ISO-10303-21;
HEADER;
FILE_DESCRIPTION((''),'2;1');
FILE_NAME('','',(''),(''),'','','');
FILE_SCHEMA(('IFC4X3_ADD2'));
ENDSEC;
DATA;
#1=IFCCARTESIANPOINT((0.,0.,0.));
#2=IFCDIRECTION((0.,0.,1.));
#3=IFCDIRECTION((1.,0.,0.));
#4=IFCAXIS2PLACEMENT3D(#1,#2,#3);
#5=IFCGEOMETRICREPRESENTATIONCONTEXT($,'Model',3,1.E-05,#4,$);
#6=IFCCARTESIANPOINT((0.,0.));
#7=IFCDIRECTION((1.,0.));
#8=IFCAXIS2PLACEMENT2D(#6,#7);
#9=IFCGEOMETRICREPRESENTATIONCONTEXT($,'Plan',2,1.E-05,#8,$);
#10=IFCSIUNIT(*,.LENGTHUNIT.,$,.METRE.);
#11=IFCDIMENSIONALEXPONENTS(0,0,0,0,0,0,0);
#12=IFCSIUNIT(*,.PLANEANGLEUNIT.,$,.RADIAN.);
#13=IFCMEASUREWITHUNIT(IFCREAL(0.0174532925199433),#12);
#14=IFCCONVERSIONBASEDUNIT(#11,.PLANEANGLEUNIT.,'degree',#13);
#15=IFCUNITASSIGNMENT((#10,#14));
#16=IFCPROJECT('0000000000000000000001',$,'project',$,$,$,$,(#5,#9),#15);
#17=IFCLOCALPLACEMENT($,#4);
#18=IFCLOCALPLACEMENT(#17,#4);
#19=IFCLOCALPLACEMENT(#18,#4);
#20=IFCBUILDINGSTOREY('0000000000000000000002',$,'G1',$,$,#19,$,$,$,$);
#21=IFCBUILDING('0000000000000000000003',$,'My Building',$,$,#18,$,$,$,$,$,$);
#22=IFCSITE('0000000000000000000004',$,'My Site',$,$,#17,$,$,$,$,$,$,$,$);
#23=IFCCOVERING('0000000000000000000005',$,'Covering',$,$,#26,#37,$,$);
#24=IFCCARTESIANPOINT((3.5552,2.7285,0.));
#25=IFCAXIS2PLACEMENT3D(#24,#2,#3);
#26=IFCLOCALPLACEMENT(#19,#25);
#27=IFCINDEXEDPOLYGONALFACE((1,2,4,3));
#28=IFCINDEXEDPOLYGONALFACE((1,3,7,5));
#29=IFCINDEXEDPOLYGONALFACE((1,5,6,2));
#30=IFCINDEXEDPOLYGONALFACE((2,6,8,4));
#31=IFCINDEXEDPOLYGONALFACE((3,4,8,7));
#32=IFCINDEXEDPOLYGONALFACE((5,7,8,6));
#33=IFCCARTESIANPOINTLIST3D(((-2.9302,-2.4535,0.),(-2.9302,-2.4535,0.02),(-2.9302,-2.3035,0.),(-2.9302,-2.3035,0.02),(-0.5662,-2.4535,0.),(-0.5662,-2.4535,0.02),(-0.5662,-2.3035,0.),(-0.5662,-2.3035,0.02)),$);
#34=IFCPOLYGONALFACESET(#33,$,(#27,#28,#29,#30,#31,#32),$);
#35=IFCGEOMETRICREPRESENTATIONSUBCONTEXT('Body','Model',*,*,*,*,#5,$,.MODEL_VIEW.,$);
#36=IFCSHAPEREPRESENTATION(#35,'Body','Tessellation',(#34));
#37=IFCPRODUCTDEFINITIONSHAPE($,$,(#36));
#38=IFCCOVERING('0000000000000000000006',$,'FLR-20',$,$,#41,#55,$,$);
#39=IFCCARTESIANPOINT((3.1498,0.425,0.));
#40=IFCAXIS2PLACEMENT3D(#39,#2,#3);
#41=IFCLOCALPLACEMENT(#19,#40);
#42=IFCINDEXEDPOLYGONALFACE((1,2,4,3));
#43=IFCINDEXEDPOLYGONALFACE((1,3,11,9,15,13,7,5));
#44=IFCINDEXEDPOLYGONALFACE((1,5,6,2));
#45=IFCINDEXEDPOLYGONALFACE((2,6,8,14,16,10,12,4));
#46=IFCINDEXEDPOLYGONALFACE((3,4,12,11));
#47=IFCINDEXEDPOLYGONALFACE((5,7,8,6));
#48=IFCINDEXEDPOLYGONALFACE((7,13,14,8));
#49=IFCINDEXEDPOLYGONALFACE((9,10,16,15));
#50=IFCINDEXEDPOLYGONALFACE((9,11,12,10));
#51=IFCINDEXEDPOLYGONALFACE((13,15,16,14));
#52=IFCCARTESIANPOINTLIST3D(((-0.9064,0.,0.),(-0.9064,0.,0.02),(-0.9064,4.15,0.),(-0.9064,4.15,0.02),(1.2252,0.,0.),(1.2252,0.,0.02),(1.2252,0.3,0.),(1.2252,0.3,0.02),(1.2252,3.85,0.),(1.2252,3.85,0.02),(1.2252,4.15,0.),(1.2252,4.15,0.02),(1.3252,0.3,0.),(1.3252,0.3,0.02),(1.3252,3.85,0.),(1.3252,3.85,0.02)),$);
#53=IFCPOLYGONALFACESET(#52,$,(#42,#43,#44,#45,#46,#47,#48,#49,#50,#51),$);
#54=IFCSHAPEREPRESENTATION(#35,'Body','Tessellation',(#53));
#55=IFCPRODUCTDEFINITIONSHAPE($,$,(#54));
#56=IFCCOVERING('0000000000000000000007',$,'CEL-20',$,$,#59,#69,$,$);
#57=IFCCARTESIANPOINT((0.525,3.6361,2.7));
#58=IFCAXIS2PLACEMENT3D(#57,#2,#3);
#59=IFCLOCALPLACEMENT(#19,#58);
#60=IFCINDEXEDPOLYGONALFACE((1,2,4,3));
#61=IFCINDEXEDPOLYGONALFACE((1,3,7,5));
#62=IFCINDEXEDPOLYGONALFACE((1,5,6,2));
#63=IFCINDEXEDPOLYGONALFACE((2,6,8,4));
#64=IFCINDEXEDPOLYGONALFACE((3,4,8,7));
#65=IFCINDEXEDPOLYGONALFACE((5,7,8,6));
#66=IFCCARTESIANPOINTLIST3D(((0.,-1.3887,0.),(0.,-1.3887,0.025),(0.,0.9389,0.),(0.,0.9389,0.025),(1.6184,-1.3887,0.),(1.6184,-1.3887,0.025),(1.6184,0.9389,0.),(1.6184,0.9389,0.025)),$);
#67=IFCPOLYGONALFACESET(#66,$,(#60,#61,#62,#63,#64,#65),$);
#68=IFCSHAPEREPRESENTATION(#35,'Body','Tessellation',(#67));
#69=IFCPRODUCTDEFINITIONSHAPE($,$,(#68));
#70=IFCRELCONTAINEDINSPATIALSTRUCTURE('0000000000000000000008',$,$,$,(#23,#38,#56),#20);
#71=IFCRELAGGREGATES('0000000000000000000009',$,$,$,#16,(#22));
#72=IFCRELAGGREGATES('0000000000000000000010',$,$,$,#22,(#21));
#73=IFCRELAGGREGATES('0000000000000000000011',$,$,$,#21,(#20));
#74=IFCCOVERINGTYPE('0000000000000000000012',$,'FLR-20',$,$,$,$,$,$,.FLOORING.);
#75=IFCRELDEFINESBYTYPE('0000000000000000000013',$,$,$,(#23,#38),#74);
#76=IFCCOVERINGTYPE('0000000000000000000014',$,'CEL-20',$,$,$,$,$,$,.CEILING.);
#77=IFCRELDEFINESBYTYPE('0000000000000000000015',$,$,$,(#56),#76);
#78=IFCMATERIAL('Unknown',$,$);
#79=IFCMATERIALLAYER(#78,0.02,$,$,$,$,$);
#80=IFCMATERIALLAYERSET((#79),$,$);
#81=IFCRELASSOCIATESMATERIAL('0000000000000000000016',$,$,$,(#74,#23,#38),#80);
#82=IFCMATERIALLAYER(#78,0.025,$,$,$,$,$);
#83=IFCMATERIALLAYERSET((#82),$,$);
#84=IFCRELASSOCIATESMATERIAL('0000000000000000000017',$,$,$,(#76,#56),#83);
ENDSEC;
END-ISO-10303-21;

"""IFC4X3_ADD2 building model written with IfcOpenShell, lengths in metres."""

from ifc_helpers import new_model, entity, si_unit, converted_unit, frame, origin_with_axes, origin_2d_with_axis, place, context, subcontext, project, spatial, line, indexed_curve, outline, extrude, material, layer, layer_set, layer_usage, type_object, element, save


model = new_model("IFC4X3_ADD2")

# Units and contexts
model_context = context("Model", 3, precision=1e-05, world=origin_with_axes())
plan_context = context("Plan", 2, precision=1e-05, world=origin_2d_with_axis())
body_context = subcontext(model_context, "Body", "Model", "MODEL_VIEW")
ifc_project = project(units=[si_unit("LENGTHUNIT", "METRE"), converted_unit("PLANEANGLEUNIT", "degree", entity("IfcReal", 0.0174532925199433), si_unit("PLANEANGLEUNIT", "RADIAN"), dimensions=[0, 0, 0, 0, 0, 0, 0])], contexts=[model_context, plan_context])

# Site, building, storey
site_placement = place(None, origin_with_axes())
site = spatial("IfcSite", under=ifc_project, at=site_placement, Name="My Site")
building_placement = place(site_placement, origin_with_axes())
building = spatial("IfcBuilding", under=site, at=building_placement, Name="My Building")
storey_placement = place(building_placement, origin_with_axes())
storey = spatial("IfcBuildingStorey", under=building, at=storey_placement, Name="G1")

# Coverings
ifc_material_1 = material(Name="Unknown")
ifc_layer_1 = layer(ifc_material_1, 0.02)
ifc_layer_set_1 = layer_set([ifc_layer_1])
ifc_layer_usage_1 = layer_usage(ifc_layer_set_1, "AXIS3", "POSITIVE", 0.0)
covering_type_1 = type_object("IfcCoveringType", Name="FLR-20", PredefinedType="FLOORING", material=ifc_layer_set_1)
covering_1_placement = place(storey_placement, frame((3.5552, 2.7285, 0.0), z_axis=(0.0, 0.0, 1.0), x_axis=(1.0, 0.0, 0.0)))
element("IfcCovering", 1, at=covering_1_placement, inside=storey, type_object=covering_type_1, material=ifc_layer_usage_1, Name="Covering", context=body_context, shape_type="SweptSolid", body=[
    extrude(outline(indexed_curve([(-2.9302, -2.4535), (-2.9302, -2.3035), (-0.5662, -2.3035), (-0.5662, -2.4535), (-2.9302, -2.4535)], segments=[line(1, 2, 3, 4, 5, 1)])), None, (0.0, 0.0, 1.0), 0.02),
])
ifc_layer_usage_2 = layer_usage(ifc_layer_set_1, "AXIS3", "POSITIVE", 0.0)
covering_2_placement = place(storey_placement, frame((3.1498, 0.425, 0.0), z_axis=(0.0, 0.0, 1.0), x_axis=(1.0, 0.0, 0.0)))
element("IfcCovering", 2, at=covering_2_placement, inside=storey, type_object=covering_type_1, material=ifc_layer_usage_2, Name="FLR-20", context=body_context, shape_type="SweptSolid", body=[
    extrude(outline(indexed_curve([(1.2252, 0.0), (1.2252, 0.3), (1.3252, 0.3), (1.3252, 3.85), (1.2252, 3.85), (1.2252, 4.15), (-0.9064, 4.15), (-0.9064, 0.0), (1.2252, 0.0)])), None, (0.0, 0.0, 1.0), 0.02),
])
ifc_layer_2 = layer(ifc_material_1, 0.025)
ifc_layer_set_2 = layer_set([ifc_layer_2])
ifc_layer_usage_3 = layer_usage(ifc_layer_set_2, "AXIS3", "POSITIVE", 0.0)
covering_type_2 = type_object("IfcCoveringType", Name="CEL-20", PredefinedType="CEILING", material=ifc_layer_set_2)
covering_3_placement = place(storey_placement, frame((0.525, 3.6361, 2.7), z_axis=(0.0, 0.0, 1.0), x_axis=(1.0, 0.0, 0.0)))
element("IfcCovering", 3, at=covering_3_placement, inside=storey, type_object=covering_type_2, material=ifc_layer_usage_3, Name="CEL-20", context=body_context, shape_type="SweptSolid", body=[
    extrude(outline(indexed_curve([(0.0, 0.9389), (1.6184, 0.9389), (1.6184, -1.3887), (0.0, -1.3887), (0.0, 0.9389)])), None, (0.0, 0.0, 1.0), 0.025),
])

save(model, "model.ifc")
